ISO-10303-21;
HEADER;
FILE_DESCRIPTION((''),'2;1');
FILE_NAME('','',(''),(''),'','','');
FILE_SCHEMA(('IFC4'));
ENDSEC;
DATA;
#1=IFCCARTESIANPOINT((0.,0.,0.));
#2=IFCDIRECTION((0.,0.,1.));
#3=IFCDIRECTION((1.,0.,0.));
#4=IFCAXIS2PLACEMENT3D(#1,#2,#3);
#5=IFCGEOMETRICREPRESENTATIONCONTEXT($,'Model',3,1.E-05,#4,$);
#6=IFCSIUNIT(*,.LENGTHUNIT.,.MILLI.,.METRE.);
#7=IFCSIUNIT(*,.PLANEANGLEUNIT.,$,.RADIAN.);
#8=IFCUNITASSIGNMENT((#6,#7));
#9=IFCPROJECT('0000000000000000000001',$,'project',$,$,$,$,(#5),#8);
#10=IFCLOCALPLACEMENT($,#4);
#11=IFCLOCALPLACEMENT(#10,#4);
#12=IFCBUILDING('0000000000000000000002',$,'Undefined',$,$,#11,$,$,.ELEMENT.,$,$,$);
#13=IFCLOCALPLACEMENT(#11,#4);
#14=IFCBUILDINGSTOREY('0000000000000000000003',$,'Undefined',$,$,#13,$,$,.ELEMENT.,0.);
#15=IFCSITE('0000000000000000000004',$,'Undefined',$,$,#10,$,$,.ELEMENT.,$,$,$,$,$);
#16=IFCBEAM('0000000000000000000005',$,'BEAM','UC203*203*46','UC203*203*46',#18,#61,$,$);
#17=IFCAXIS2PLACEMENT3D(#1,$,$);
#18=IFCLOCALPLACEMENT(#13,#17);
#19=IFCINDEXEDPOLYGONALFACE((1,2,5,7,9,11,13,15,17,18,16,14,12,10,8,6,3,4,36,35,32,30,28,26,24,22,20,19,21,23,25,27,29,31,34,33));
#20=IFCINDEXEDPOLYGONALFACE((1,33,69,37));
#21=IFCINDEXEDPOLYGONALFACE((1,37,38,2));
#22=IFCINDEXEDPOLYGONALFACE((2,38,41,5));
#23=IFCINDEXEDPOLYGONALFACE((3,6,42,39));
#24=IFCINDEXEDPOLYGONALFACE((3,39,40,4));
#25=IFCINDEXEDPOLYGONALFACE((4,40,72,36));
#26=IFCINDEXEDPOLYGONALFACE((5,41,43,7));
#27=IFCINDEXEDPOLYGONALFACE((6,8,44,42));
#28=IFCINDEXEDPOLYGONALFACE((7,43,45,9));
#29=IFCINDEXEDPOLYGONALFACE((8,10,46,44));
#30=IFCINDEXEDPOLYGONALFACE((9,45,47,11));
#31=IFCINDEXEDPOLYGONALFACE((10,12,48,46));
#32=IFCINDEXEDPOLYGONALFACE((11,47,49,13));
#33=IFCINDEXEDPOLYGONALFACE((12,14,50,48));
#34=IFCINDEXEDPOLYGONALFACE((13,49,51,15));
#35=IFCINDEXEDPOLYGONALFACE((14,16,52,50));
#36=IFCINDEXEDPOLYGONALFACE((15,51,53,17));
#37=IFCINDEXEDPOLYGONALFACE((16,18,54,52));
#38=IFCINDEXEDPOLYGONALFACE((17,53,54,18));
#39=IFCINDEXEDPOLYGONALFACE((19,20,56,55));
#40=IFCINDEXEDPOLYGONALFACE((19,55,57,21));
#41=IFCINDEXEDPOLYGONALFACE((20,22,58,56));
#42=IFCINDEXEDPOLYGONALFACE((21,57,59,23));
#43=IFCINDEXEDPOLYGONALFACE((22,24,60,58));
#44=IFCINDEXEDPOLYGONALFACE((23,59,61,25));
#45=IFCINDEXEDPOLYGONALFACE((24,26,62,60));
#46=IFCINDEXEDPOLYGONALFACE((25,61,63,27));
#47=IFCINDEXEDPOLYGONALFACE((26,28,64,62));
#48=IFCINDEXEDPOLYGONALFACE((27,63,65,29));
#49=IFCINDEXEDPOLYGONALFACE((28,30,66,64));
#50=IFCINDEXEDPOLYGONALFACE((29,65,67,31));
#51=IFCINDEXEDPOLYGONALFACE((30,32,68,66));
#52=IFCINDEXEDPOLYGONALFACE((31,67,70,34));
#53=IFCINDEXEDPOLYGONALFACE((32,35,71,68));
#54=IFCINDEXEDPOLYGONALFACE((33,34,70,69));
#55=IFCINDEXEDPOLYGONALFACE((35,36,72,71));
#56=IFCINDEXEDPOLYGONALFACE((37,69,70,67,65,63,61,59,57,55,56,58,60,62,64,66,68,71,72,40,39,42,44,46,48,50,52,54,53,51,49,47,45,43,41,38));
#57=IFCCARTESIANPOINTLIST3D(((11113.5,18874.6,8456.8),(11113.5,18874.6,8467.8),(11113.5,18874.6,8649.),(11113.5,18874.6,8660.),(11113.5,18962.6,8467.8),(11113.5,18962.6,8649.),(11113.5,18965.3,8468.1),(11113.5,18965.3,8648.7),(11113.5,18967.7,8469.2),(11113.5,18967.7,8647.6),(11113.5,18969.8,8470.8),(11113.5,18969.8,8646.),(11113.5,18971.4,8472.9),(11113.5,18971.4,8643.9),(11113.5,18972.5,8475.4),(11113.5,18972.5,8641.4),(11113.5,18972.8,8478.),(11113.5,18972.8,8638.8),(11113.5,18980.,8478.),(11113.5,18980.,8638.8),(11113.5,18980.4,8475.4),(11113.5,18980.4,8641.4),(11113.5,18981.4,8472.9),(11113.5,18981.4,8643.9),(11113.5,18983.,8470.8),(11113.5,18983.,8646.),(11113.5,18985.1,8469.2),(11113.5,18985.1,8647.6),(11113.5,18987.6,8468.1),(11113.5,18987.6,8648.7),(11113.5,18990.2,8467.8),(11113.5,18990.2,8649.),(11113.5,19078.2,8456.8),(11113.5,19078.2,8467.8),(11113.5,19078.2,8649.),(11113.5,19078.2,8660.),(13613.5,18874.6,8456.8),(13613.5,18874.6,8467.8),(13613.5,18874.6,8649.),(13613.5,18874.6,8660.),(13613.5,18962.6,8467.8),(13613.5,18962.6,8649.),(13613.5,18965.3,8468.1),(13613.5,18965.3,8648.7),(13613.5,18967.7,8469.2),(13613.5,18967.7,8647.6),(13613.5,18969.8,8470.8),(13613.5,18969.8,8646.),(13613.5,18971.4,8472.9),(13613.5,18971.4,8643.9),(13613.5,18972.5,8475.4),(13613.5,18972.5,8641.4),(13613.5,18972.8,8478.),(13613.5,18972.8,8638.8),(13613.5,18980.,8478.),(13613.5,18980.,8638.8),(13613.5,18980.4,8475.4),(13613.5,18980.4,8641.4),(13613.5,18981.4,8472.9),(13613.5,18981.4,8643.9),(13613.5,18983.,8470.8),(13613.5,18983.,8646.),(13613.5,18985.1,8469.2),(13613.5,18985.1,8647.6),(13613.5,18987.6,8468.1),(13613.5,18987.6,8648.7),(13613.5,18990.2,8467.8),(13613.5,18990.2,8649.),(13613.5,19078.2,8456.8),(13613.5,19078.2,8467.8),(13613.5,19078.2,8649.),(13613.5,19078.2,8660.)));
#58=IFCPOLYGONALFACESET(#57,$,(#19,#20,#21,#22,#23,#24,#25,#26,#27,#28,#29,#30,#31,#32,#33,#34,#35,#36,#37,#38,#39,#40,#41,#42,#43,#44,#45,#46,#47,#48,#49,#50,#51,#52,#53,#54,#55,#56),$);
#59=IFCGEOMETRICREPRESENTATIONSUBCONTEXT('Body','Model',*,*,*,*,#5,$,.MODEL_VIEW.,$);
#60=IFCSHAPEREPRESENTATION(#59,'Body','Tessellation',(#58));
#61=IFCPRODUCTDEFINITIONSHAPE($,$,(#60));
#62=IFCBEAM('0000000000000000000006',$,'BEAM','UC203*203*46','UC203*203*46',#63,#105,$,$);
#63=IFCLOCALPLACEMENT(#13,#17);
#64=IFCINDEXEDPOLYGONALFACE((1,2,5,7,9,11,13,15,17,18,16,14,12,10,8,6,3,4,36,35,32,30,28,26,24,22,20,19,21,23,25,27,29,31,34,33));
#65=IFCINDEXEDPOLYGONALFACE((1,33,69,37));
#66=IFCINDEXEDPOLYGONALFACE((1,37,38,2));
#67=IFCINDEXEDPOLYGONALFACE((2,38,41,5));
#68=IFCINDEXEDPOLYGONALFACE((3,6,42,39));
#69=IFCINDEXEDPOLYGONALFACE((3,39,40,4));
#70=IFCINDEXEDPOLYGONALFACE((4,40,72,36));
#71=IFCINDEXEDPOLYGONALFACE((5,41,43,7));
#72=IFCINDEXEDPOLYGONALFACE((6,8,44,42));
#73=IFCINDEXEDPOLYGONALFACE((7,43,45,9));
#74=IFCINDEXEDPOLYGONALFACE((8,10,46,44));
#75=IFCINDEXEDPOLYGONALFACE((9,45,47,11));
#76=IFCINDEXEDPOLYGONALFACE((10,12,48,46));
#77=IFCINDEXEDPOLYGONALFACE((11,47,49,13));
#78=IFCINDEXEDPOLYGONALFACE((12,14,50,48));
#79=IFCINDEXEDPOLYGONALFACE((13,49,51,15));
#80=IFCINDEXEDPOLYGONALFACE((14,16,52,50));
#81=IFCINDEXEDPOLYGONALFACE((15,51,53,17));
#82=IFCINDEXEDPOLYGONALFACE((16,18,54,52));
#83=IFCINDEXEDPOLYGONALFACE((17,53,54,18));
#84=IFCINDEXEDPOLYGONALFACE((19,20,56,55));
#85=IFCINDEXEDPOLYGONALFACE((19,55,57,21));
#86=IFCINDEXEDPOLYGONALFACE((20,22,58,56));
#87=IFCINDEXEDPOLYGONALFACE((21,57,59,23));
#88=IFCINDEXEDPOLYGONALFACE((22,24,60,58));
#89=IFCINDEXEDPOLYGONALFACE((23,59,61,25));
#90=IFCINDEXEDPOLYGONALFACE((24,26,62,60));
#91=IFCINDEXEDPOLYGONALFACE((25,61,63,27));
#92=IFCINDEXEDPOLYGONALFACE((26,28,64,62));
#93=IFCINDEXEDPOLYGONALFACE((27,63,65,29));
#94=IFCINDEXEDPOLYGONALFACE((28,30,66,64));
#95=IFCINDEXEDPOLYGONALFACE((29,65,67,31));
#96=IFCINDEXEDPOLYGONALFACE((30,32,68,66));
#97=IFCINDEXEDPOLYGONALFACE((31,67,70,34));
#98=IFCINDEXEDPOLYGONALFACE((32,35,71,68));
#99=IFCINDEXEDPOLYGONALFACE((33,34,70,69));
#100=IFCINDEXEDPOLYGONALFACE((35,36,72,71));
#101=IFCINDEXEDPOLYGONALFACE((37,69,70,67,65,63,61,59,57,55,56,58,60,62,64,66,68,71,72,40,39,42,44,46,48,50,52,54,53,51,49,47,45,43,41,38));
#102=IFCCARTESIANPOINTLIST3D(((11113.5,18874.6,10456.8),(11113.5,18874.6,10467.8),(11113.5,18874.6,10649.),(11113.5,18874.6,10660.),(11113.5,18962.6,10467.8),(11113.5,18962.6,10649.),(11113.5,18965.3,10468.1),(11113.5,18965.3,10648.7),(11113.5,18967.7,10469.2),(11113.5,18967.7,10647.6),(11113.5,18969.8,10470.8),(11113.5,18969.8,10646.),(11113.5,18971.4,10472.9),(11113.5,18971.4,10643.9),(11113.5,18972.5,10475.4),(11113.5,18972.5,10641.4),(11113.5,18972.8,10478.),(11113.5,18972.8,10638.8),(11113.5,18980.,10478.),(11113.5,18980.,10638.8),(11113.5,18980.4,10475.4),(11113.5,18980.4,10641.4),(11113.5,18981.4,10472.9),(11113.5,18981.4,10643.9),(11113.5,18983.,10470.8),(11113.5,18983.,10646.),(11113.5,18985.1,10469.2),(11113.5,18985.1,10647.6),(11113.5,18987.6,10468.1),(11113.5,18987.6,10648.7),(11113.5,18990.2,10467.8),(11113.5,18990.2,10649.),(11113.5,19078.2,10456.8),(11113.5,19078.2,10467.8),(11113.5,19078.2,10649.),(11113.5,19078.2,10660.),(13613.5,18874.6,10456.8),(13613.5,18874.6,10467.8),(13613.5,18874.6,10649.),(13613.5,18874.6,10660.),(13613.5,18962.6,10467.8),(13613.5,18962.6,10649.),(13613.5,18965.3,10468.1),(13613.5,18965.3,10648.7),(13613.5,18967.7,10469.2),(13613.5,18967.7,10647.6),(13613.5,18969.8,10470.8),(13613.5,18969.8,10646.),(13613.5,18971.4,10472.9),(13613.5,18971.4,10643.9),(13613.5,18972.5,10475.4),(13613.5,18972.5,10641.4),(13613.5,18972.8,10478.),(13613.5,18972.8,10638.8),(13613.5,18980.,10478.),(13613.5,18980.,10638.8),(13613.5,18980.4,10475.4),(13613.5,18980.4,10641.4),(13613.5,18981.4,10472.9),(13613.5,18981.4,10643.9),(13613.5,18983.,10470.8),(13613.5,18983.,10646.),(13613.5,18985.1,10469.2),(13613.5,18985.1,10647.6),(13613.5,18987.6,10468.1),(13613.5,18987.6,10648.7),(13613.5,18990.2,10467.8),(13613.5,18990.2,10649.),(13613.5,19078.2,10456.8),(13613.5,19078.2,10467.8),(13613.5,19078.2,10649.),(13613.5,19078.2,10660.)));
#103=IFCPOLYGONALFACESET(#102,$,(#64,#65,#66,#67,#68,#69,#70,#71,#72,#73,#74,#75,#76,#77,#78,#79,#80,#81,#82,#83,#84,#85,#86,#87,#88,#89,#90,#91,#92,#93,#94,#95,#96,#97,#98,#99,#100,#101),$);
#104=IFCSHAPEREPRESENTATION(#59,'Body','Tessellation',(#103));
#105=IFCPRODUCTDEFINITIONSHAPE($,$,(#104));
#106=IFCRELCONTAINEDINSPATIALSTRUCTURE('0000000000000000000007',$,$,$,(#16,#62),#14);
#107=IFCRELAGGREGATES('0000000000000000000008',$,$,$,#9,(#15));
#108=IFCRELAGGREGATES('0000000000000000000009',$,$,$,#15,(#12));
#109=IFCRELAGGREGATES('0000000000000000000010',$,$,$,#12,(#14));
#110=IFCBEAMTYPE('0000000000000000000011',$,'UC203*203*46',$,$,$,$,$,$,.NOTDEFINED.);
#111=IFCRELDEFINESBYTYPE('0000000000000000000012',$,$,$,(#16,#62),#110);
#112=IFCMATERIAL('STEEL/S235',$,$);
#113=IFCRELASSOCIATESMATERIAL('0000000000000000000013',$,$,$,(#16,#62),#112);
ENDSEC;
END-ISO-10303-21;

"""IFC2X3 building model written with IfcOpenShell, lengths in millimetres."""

from ifc_helpers import new_model, si_unit, frame, origin_with_axes, origin_2d_with_axis, place, context, subcontext, project, spatial, i_section, extrude, material, type_object, element, save


model = new_model("IFC2X3")

# Units and contexts
model_context = context("Model", 3, precision=1e-05, world=origin_with_axes())
body_context = subcontext(model_context, "Body", "Model", "MODEL_VIEW")
ifc_project = project(units=[si_unit("LENGTHUNIT", "METRE", prefix="MILLI"), si_unit("PLANEANGLEUNIT", "RADIAN")], contexts=[model_context])

# Site, building, storey
site_placement = place(None, origin_with_axes())
site = spatial("IfcSite", under=ifc_project, at=site_placement, Name="Undefined", CompositionType="ELEMENT")
building_placement = place(site_placement, origin_with_axes())
building = spatial("IfcBuilding", under=site, at=building_placement, Name="Undefined", CompositionType="ELEMENT")
storey_placement = place(building_placement, origin_with_axes())
storey = spatial("IfcBuildingStorey", under=building, at=storey_placement, Name="Undefined", CompositionType="ELEMENT", Elevation=0.0)

# Shared definitions
ifc_material = material(Name="STEEL/S235")

# Beams
beam_type_1 = type_object("IfcBeamType", Name="UC203*203*46", PredefinedType="NOTDEFINED")
for number, where, z_axis, x_axis, name in (
    (1, (11113.5, 18976.4, 8558.4), (0.0, 0.0, 1.0), (1.0, 0.0, 0.0), "BEAM"),
    (2, (11113.5, 18976.4, 10558.4), (0.0, 0.0, 1.0), (1.0, 0.0, 0.0), "BEAM"),
):
    element("IfcBeam", number, at=place(storey_placement, frame(where, z_axis=z_axis, x_axis=x_axis)), inside=storey, type_object=beam_type_1, material=ifc_material, Name=name, Description="UC203*203*46", ObjectType="UC203*203*46", context=body_context, shape_type="SweptSolid", body=[
        extrude(i_section(OverallWidth=203.6, OverallDepth=203.2, WebThickness=7.2, FlangeThickness=11.0, FilletRadius=10.2, at=origin_2d_with_axis()), frame((2500.0, 0.0, 0.0), z_axis=(-1.0, 0.0, 0.0), x_axis=(0.0, -1.0, 0.0)), (0.0, 0.0, 1.0), 2500.0),
    ])

save(model, "model.ifc")
